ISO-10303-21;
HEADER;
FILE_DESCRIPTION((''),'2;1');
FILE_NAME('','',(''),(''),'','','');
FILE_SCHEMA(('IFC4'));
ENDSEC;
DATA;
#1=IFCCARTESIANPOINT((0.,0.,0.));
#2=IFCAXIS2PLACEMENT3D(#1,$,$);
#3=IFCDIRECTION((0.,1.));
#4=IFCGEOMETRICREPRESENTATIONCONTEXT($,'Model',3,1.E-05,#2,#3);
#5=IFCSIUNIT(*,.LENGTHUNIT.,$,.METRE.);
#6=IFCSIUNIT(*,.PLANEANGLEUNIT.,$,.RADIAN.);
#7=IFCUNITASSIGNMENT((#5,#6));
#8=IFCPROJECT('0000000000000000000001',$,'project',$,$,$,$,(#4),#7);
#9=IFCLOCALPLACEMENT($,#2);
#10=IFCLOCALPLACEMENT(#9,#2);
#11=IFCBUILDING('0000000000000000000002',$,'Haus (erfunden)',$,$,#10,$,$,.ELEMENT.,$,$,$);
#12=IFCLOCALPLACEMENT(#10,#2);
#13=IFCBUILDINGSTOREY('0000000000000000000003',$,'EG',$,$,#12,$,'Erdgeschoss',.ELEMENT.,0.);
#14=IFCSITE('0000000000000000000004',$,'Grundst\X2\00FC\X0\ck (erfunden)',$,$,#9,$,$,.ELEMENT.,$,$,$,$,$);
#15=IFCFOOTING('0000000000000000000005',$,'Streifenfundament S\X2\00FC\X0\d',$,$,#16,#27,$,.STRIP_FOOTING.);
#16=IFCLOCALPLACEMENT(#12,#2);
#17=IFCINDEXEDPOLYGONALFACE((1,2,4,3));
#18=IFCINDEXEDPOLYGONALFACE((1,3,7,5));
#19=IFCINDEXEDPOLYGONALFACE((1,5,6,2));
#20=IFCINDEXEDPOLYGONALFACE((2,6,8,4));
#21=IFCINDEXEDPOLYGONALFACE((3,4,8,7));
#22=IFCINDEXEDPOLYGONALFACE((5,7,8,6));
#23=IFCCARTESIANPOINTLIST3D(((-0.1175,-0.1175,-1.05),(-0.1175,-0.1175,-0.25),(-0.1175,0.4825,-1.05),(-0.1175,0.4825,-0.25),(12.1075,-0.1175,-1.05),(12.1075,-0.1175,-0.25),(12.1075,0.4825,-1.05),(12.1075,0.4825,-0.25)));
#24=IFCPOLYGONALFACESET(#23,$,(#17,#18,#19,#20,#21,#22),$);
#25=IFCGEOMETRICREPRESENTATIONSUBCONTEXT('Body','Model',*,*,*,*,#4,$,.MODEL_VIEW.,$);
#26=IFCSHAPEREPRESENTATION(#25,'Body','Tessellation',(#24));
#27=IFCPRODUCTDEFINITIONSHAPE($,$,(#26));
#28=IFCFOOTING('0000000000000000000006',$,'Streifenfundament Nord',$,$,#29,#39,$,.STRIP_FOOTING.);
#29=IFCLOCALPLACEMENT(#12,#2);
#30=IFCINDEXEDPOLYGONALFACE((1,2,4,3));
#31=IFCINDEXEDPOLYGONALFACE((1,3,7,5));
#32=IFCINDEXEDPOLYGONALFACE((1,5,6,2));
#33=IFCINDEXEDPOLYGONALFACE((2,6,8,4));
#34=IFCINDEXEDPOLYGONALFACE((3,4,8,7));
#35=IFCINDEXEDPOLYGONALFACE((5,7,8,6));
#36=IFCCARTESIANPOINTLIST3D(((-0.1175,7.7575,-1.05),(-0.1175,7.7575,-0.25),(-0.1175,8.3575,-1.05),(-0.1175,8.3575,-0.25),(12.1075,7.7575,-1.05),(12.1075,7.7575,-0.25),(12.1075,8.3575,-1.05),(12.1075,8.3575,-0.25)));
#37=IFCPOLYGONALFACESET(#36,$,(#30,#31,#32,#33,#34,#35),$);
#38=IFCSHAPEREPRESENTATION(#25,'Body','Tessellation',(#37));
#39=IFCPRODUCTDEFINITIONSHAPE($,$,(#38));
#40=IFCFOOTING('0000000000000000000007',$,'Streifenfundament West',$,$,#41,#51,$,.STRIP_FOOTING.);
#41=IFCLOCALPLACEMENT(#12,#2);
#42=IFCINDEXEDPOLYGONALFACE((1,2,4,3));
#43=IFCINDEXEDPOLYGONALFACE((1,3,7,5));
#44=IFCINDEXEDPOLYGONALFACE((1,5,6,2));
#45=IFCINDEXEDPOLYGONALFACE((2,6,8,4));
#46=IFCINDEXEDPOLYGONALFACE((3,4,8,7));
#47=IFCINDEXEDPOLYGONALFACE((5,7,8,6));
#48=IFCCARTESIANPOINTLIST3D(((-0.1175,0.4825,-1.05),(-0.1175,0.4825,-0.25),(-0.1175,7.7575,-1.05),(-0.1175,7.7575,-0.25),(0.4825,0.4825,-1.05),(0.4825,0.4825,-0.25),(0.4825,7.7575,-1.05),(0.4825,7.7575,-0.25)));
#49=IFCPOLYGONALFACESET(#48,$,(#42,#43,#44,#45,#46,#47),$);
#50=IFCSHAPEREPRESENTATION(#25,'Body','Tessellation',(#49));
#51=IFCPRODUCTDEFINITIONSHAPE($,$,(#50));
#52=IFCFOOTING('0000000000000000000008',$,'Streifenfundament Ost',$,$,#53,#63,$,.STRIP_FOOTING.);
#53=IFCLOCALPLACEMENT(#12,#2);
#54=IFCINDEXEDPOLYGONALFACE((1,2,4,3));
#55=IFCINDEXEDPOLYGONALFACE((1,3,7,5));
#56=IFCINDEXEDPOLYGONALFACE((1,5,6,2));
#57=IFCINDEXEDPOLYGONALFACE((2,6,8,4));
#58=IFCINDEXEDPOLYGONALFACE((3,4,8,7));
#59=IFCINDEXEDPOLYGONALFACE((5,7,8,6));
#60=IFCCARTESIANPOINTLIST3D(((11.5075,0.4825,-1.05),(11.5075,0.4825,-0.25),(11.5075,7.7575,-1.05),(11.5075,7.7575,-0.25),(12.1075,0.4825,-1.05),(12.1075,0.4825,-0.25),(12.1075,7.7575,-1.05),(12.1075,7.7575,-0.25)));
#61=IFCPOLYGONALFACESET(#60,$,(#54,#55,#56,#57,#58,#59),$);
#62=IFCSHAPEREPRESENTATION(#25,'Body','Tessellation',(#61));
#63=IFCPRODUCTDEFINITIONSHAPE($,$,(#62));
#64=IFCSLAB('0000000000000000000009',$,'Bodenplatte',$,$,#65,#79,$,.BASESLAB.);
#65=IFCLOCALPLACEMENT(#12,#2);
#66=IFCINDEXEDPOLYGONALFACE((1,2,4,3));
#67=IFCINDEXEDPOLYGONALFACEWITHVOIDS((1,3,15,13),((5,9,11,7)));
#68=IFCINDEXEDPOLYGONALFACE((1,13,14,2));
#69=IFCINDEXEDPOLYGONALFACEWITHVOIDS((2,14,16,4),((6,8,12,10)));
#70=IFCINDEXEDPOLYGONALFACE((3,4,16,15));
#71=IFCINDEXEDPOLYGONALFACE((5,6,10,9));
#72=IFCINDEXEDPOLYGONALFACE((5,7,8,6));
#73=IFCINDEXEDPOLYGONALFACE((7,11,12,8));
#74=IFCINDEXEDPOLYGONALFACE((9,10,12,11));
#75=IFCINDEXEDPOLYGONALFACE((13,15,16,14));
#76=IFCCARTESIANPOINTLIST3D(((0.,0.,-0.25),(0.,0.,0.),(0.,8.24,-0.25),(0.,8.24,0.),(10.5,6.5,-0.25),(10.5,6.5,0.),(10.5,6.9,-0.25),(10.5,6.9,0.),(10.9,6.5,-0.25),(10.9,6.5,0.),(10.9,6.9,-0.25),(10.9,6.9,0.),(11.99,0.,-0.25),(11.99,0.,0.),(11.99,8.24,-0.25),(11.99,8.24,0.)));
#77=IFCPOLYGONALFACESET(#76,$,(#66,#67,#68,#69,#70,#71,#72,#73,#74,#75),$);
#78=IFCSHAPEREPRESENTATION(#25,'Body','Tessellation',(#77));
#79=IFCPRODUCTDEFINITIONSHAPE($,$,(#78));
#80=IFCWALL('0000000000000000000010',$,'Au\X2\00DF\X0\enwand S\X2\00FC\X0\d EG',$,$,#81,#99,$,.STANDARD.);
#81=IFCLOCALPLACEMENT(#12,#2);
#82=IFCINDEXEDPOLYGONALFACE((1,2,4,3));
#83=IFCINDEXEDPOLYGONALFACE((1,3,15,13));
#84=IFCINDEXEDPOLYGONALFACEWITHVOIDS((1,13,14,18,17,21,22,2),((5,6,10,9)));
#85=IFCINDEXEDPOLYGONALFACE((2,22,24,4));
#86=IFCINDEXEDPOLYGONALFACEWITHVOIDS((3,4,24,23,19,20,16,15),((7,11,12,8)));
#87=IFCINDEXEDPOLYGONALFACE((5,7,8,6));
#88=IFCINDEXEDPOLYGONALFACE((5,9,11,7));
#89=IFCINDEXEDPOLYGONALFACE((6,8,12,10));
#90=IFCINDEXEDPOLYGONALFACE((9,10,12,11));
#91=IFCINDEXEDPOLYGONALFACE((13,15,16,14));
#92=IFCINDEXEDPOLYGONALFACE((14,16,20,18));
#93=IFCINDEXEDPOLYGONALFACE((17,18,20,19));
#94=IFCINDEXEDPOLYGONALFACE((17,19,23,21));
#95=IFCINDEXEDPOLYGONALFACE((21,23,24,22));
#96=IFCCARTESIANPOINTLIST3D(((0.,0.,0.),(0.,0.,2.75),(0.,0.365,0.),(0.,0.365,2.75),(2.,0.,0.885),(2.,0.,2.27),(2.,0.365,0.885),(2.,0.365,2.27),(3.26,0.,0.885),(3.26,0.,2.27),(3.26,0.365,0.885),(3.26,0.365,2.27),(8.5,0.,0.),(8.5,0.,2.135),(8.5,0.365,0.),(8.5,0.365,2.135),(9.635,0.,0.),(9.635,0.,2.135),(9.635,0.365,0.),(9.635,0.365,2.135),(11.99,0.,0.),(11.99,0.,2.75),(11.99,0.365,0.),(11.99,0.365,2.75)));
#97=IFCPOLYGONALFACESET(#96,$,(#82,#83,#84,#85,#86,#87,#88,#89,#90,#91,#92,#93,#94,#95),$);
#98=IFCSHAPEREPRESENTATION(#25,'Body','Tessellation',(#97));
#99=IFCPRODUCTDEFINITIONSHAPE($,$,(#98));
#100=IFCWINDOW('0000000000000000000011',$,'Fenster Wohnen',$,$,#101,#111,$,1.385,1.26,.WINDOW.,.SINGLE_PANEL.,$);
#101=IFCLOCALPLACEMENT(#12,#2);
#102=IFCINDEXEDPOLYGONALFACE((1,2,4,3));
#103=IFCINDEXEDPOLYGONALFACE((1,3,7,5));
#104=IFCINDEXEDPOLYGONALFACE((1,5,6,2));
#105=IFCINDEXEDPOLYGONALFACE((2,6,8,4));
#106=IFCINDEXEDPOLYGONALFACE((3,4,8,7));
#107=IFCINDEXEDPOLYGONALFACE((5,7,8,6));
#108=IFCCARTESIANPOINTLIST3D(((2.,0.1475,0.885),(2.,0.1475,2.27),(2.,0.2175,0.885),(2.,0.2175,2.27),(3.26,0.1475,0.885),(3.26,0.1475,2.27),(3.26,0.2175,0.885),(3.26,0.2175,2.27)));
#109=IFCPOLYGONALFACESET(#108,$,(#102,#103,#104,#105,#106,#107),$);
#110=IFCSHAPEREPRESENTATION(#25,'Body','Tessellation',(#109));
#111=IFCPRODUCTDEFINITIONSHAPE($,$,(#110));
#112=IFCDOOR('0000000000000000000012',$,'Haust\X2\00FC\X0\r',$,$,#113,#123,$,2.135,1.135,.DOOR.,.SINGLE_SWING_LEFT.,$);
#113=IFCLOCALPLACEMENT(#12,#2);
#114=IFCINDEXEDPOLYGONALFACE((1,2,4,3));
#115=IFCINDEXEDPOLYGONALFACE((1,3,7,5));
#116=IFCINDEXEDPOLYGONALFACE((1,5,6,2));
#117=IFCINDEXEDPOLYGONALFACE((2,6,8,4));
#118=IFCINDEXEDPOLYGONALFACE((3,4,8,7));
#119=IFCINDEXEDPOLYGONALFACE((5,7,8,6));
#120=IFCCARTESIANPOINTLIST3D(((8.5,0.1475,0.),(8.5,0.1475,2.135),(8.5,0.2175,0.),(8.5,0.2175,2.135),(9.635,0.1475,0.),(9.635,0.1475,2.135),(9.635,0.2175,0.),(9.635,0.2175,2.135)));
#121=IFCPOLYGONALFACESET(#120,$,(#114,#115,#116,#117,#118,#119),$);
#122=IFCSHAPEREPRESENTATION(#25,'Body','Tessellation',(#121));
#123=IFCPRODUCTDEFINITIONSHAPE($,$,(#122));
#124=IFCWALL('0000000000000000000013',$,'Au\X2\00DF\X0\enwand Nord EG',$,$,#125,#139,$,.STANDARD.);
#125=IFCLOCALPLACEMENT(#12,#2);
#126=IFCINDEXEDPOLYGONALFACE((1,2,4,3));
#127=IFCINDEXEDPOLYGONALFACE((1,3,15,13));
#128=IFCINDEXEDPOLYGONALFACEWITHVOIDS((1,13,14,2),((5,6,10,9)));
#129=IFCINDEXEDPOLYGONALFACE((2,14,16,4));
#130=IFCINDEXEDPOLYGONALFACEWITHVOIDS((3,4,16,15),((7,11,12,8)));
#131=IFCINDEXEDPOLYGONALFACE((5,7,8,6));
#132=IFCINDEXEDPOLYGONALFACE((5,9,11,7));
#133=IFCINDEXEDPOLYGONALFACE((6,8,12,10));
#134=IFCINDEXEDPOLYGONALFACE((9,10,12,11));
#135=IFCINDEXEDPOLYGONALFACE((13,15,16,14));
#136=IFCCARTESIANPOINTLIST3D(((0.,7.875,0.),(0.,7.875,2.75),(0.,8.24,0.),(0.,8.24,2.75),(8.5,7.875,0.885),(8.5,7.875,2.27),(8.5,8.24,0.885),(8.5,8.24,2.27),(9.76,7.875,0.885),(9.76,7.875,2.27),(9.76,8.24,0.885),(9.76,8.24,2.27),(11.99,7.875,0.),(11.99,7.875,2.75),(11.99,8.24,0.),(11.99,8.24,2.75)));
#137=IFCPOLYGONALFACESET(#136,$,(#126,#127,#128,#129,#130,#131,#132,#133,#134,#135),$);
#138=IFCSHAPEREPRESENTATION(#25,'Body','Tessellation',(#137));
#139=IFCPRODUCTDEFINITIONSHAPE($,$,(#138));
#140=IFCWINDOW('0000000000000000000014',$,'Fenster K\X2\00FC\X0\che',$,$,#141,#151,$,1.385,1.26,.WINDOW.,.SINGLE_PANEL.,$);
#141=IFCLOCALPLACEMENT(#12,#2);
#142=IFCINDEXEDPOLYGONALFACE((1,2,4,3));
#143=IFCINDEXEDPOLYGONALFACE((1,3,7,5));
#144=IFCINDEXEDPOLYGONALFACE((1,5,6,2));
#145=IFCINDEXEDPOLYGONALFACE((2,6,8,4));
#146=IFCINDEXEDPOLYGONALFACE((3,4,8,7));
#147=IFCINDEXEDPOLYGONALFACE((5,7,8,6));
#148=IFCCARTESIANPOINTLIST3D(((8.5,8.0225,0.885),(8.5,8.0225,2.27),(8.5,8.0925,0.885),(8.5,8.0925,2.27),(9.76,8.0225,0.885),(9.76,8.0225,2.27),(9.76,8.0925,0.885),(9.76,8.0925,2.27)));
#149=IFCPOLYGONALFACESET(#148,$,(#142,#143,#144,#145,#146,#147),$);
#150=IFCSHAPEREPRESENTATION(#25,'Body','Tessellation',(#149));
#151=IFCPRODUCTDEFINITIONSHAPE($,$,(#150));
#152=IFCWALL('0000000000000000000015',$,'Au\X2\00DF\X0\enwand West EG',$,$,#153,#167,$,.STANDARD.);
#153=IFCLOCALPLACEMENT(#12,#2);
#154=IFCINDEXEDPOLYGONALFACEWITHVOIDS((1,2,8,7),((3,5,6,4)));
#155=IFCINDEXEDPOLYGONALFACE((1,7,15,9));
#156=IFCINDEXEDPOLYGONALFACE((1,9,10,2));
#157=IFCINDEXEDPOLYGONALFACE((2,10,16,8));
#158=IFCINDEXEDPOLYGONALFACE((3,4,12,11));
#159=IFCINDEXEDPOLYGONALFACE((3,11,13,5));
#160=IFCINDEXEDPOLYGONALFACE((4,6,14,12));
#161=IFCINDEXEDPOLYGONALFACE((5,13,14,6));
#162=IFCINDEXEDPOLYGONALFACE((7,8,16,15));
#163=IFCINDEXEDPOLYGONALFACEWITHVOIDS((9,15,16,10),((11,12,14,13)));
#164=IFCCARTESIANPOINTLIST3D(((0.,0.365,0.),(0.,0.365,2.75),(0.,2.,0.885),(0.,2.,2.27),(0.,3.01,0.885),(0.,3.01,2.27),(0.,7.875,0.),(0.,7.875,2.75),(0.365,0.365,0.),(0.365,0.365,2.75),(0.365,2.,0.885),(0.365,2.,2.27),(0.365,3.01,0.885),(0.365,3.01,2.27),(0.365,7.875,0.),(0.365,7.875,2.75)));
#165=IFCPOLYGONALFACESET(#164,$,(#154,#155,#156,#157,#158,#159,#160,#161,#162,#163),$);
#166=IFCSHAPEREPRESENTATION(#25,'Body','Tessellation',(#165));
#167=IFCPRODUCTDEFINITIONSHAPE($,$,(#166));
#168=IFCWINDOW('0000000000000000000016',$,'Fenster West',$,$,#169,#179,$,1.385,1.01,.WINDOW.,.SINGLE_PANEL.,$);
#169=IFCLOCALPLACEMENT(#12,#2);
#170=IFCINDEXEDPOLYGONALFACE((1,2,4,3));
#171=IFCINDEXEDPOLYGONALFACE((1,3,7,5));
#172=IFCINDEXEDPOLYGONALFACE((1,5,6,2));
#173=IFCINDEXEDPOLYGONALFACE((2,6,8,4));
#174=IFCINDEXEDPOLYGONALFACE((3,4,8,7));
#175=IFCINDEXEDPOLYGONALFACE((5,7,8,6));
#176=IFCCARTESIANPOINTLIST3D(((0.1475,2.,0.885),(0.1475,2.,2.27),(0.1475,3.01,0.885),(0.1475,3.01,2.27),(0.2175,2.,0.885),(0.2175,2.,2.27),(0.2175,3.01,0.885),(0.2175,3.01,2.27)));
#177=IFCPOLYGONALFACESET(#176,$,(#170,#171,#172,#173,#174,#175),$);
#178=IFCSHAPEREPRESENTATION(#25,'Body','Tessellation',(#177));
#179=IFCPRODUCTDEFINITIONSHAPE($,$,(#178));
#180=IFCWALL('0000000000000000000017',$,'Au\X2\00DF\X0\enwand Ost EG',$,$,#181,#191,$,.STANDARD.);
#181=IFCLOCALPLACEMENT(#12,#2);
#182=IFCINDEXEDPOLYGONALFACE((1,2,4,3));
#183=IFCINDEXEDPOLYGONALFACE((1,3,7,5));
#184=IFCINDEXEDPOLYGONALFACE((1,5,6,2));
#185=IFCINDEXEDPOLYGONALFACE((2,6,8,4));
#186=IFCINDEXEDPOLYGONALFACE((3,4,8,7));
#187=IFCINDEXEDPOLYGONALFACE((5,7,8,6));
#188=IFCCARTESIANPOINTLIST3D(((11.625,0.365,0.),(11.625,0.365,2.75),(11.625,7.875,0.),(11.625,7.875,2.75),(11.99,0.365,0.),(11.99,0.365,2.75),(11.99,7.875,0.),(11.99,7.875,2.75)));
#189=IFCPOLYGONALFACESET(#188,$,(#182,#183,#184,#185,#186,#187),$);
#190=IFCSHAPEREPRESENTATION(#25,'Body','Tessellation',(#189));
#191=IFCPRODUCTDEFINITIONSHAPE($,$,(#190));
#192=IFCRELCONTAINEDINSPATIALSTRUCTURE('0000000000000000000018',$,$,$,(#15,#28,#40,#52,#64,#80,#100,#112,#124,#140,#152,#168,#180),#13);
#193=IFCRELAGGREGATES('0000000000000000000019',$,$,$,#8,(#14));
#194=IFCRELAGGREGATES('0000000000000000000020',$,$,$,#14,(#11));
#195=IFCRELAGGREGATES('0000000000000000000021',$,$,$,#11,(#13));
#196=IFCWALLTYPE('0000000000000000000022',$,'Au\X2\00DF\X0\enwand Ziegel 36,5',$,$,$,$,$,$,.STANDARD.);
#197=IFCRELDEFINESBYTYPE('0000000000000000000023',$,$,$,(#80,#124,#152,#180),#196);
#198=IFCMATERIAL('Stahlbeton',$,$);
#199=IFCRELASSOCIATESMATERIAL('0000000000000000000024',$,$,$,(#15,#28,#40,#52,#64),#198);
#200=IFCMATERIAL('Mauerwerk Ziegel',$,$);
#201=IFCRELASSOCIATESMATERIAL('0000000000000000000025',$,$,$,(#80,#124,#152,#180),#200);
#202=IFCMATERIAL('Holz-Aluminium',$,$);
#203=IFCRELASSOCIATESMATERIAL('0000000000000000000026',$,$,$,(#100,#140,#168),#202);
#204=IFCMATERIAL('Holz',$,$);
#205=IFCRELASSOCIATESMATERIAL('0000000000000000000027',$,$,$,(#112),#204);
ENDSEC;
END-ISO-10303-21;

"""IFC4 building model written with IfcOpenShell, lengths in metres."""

from ifc_helpers import new_model, si_unit, direction, frame, frame_2d, origin, place, context, subcontext, project, spatial, rectangle, extrude, material, type_object, element, fill, save


model = new_model("IFC4")

# Units and contexts
model_context = context("Model", 3, precision=1e-05, world=origin(), true_north=direction((0.0, 1.0)))
body_context = subcontext(model_context, "Body", "Model", "MODEL_VIEW")
ifc_project = project(units=[si_unit("LENGTHUNIT", "METRE"), si_unit("PLANEANGLEUNIT", "RADIAN")], contexts=[model_context])

# Site, building, storey
site_placement = place(None, origin())
site = spatial("IfcSite", under=ifc_project, at=site_placement, Name="Grundstück (erfunden)", CompositionType="ELEMENT")
building_placement = place(site_placement, origin())
building = spatial("IfcBuilding", under=site, at=building_placement, Name="Haus (erfunden)", CompositionType="ELEMENT")
storey_placement = place(building_placement, origin())
storey = spatial("IfcBuildingStorey", under=building, at=storey_placement, Name="EG", LongName="Erdgeschoss", CompositionType="ELEMENT", Elevation=0.0)

# Footings
ifc_material_1 = material(Name="Stahlbeton")
for number, where, name in (
    (1, (-0.1175, -0.1175, -1.05), "Streifenfundament Süd"),
    (2, (-0.1175, 7.7575, -1.05), "Streifenfundament Nord"),
):
    element("IfcFooting", number, at=place(storey_placement, frame(where)), inside=storey, material=ifc_material_1, Name=name, PredefinedType="STRIP_FOOTING", context=body_context, shape_type="SweptSolid", body=[
        extrude(rectangle(XDim=12.225, YDim=0.6, at=frame_2d((6.1125, 0.3))), origin(), (0.0, 0.0, 1.0), 0.8),
    ])
for number, where, name in (
    (3, (-0.1175, 0.4825, -1.05), "Streifenfundament West"),
    (4, (11.5075, 0.4825, -1.05), "Streifenfundament Ost"),
):
    element("IfcFooting", number, at=place(storey_placement, frame(where)), inside=storey, material=ifc_material_1, Name=name, PredefinedType="STRIP_FOOTING", context=body_context, shape_type="SweptSolid", body=[
        extrude(rectangle(XDim=0.6, YDim=7.275, at=frame_2d((0.3, 3.6375))), origin(), (0.0, 0.0, 1.0), 0.8),
    ])

# Slab, opening
slab_placement = place(storey_placement, frame((0.0, 0.0, -0.25)))
slab = element("IfcSlab", 5, at=slab_placement, inside=storey, material=ifc_material_1, Name="Bodenplatte", PredefinedType="BASESLAB", context=body_context, shape_type="SweptSolid", body=[
    extrude(rectangle(XDim=11.99, YDim=8.24, at=frame_2d((5.995, 4.12))), origin(), (0.0, 0.0, 1.0), 0.25),
])
opening_1_placement = place(slab_placement, frame((10.5, 6.5, -0.05)))
element("IfcOpeningElement", 6, at=opening_1_placement, cuts=slab, PredefinedType="OPENING", context=body_context, shape_type="SweptSolid", body=[
    extrude(rectangle(XDim=0.4, YDim=0.4, at=frame_2d((0.2, 0.2))), origin(), (0.0, 0.0, 1.0), 0.35),
])

# Wall, openings, window, door
ifc_material_2 = material(Name="Mauerwerk Ziegel")
wall_type_1 = type_object("IfcWallType", Name="Außenwand Ziegel 36,5", PredefinedType="STANDARD")
wall_1_placement = place(storey_placement, origin())
wall_1 = element("IfcWall", 7, at=wall_1_placement, inside=storey, type_object=wall_type_1, material=ifc_material_2, Name="Außenwand Süd EG", PredefinedType="STANDARD", context=body_context, shape_type="SweptSolid", body=[
    extrude(rectangle(XDim=11.99, YDim=0.365, at=frame_2d((5.995, 0.1825))), origin(), (0.0, 0.0, 1.0), 2.75),
])
opening_2_placement = place(wall_1_placement, frame((2.0, -0.05, 0.885)))
opening_2 = element("IfcOpeningElement", 8, at=opening_2_placement, cuts=wall_1, PredefinedType="OPENING", context=body_context, shape_type="SweptSolid", body=[
    extrude(rectangle(XDim=1.26, YDim=0.465, at=frame_2d((0.63, 0.2325))), origin(), (0.0, 0.0, 1.0), 1.385),
])
opening_3_placement = place(wall_1_placement, frame((8.5, -0.05, 0.0)))
opening_3 = element("IfcOpeningElement", 9, at=opening_3_placement, cuts=wall_1, PredefinedType="OPENING", context=body_context, shape_type="SweptSolid", body=[
    extrude(rectangle(XDim=1.135, YDim=0.465, at=frame_2d((0.5675, 0.2325))), origin(), (0.0, 0.0, 1.0), 2.135),
])
ifc_material_3 = material(Name="Holz-Aluminium")
window_1_placement = place(opening_2_placement, frame((0.0, 0.1975, 0.0)))
window_1 = element("IfcWindow", 10, at=window_1_placement, inside=storey, material=ifc_material_3, Name="Fenster Wohnen", OverallHeight=1.385, OverallWidth=1.26, PartitioningType="SINGLE_PANEL", PredefinedType="WINDOW", context=body_context, shape_type="SweptSolid", body=[
    extrude(rectangle(XDim=1.26, YDim=0.07, at=frame_2d((0.63, 0.035))), origin(), (0.0, 0.0, 1.0), 1.385),
])
fill(opening_2, window_1)
ifc_material_4 = material(Name="Holz")
door_1_placement = place(opening_3_placement, frame((0.0, 0.1975, 0.0)))
door_1 = element("IfcDoor", 11, at=door_1_placement, inside=storey, material=ifc_material_4, Name="Haustür", OperationType="SINGLE_SWING_LEFT", OverallHeight=2.135, OverallWidth=1.135, PredefinedType="DOOR", context=body_context, shape_type="SweptSolid", body=[
    extrude(rectangle(XDim=1.135, YDim=0.07, at=frame_2d((0.5675, 0.035))), origin(), (0.0, 0.0, 1.0), 2.135),
])
fill(opening_3, door_1)

# Walls, openings, windows
wall_2_placement = place(storey_placement, frame((0.0, 7.875, 0.0)))
wall_2 = element("IfcWall", 12, at=wall_2_placement, inside=storey, type_object=wall_type_1, material=ifc_material_2, Name="Außenwand Nord EG", PredefinedType="STANDARD", context=body_context, shape_type="SweptSolid", body=[
    extrude(rectangle(XDim=11.99, YDim=0.365, at=frame_2d((5.995, 0.1825))), origin(), (0.0, 0.0, 1.0), 2.75),
])
opening_4_placement = place(wall_2_placement, frame((8.5, -0.05, 0.885)))
opening_4 = element("IfcOpeningElement", 13, at=opening_4_placement, cuts=wall_2, PredefinedType="OPENING", context=body_context, shape_type="SweptSolid", body=[
    extrude(rectangle(XDim=1.26, YDim=0.465, at=frame_2d((0.63, 0.2325))), origin(), (0.0, 0.0, 1.0), 1.385),
])
window_2_placement = place(opening_4_placement, frame((0.0, 0.1975, 0.0)))
window_2 = element("IfcWindow", 14, at=window_2_placement, inside=storey, material=ifc_material_3, Name="Fenster Küche", OverallHeight=1.385, OverallWidth=1.26, PartitioningType="SINGLE_PANEL", PredefinedType="WINDOW", context=body_context, shape_type="SweptSolid", body=[
    extrude(rectangle(XDim=1.26, YDim=0.07, at=frame_2d((0.63, 0.035))), origin(), (0.0, 0.0, 1.0), 1.385),
])
fill(opening_4, window_2)
wall_3_placement = place(storey_placement, frame((0.0, 0.365, 0.0)))
wall_3 = element("IfcWall", 15, at=wall_3_placement, inside=storey, type_object=wall_type_1, material=ifc_material_2, Name="Außenwand West EG", PredefinedType="STANDARD", context=body_context, shape_type="SweptSolid", body=[
    extrude(rectangle(XDim=0.365, YDim=7.51, at=frame_2d((0.1825, 3.755))), origin(), (0.0, 0.0, 1.0), 2.75),
])
opening_5_placement = place(wall_3_placement, frame((-0.05, 1.635, 0.885)))
opening_5 = element("IfcOpeningElement", 16, at=opening_5_placement, cuts=wall_3, PredefinedType="OPENING", context=body_context, shape_type="SweptSolid", body=[
    extrude(rectangle(XDim=0.465, YDim=1.01, at=frame_2d((0.2325, 0.505))), origin(), (0.0, 0.0, 1.0), 1.385),
])
window_3_placement = place(opening_5_placement, frame((0.1975, 0.0, 0.0)))
window_3 = element("IfcWindow", 17, at=window_3_placement, inside=storey, material=ifc_material_3, Name="Fenster West", OverallHeight=1.385, OverallWidth=1.01, PartitioningType="SINGLE_PANEL", PredefinedType="WINDOW", context=body_context, shape_type="SweptSolid", body=[
    extrude(rectangle(XDim=0.07, YDim=1.01, at=frame_2d((0.035, 0.505))), origin(), (0.0, 0.0, 1.0), 1.385),
])
fill(opening_5, window_3)

# Wall
wall_4_placement = place(storey_placement, frame((11.625, 0.365, 0.0)))
element("IfcWall", 18, at=wall_4_placement, inside=storey, type_object=wall_type_1, material=ifc_material_2, Name="Außenwand Ost EG", PredefinedType="STANDARD", context=body_context, shape_type="SweptSolid", body=[
    extrude(rectangle(XDim=0.365, YDim=7.51, at=frame_2d((0.1825, 3.755))), origin(), (0.0, 0.0, 1.0), 2.75),
])

save(model, "model.ifc")
